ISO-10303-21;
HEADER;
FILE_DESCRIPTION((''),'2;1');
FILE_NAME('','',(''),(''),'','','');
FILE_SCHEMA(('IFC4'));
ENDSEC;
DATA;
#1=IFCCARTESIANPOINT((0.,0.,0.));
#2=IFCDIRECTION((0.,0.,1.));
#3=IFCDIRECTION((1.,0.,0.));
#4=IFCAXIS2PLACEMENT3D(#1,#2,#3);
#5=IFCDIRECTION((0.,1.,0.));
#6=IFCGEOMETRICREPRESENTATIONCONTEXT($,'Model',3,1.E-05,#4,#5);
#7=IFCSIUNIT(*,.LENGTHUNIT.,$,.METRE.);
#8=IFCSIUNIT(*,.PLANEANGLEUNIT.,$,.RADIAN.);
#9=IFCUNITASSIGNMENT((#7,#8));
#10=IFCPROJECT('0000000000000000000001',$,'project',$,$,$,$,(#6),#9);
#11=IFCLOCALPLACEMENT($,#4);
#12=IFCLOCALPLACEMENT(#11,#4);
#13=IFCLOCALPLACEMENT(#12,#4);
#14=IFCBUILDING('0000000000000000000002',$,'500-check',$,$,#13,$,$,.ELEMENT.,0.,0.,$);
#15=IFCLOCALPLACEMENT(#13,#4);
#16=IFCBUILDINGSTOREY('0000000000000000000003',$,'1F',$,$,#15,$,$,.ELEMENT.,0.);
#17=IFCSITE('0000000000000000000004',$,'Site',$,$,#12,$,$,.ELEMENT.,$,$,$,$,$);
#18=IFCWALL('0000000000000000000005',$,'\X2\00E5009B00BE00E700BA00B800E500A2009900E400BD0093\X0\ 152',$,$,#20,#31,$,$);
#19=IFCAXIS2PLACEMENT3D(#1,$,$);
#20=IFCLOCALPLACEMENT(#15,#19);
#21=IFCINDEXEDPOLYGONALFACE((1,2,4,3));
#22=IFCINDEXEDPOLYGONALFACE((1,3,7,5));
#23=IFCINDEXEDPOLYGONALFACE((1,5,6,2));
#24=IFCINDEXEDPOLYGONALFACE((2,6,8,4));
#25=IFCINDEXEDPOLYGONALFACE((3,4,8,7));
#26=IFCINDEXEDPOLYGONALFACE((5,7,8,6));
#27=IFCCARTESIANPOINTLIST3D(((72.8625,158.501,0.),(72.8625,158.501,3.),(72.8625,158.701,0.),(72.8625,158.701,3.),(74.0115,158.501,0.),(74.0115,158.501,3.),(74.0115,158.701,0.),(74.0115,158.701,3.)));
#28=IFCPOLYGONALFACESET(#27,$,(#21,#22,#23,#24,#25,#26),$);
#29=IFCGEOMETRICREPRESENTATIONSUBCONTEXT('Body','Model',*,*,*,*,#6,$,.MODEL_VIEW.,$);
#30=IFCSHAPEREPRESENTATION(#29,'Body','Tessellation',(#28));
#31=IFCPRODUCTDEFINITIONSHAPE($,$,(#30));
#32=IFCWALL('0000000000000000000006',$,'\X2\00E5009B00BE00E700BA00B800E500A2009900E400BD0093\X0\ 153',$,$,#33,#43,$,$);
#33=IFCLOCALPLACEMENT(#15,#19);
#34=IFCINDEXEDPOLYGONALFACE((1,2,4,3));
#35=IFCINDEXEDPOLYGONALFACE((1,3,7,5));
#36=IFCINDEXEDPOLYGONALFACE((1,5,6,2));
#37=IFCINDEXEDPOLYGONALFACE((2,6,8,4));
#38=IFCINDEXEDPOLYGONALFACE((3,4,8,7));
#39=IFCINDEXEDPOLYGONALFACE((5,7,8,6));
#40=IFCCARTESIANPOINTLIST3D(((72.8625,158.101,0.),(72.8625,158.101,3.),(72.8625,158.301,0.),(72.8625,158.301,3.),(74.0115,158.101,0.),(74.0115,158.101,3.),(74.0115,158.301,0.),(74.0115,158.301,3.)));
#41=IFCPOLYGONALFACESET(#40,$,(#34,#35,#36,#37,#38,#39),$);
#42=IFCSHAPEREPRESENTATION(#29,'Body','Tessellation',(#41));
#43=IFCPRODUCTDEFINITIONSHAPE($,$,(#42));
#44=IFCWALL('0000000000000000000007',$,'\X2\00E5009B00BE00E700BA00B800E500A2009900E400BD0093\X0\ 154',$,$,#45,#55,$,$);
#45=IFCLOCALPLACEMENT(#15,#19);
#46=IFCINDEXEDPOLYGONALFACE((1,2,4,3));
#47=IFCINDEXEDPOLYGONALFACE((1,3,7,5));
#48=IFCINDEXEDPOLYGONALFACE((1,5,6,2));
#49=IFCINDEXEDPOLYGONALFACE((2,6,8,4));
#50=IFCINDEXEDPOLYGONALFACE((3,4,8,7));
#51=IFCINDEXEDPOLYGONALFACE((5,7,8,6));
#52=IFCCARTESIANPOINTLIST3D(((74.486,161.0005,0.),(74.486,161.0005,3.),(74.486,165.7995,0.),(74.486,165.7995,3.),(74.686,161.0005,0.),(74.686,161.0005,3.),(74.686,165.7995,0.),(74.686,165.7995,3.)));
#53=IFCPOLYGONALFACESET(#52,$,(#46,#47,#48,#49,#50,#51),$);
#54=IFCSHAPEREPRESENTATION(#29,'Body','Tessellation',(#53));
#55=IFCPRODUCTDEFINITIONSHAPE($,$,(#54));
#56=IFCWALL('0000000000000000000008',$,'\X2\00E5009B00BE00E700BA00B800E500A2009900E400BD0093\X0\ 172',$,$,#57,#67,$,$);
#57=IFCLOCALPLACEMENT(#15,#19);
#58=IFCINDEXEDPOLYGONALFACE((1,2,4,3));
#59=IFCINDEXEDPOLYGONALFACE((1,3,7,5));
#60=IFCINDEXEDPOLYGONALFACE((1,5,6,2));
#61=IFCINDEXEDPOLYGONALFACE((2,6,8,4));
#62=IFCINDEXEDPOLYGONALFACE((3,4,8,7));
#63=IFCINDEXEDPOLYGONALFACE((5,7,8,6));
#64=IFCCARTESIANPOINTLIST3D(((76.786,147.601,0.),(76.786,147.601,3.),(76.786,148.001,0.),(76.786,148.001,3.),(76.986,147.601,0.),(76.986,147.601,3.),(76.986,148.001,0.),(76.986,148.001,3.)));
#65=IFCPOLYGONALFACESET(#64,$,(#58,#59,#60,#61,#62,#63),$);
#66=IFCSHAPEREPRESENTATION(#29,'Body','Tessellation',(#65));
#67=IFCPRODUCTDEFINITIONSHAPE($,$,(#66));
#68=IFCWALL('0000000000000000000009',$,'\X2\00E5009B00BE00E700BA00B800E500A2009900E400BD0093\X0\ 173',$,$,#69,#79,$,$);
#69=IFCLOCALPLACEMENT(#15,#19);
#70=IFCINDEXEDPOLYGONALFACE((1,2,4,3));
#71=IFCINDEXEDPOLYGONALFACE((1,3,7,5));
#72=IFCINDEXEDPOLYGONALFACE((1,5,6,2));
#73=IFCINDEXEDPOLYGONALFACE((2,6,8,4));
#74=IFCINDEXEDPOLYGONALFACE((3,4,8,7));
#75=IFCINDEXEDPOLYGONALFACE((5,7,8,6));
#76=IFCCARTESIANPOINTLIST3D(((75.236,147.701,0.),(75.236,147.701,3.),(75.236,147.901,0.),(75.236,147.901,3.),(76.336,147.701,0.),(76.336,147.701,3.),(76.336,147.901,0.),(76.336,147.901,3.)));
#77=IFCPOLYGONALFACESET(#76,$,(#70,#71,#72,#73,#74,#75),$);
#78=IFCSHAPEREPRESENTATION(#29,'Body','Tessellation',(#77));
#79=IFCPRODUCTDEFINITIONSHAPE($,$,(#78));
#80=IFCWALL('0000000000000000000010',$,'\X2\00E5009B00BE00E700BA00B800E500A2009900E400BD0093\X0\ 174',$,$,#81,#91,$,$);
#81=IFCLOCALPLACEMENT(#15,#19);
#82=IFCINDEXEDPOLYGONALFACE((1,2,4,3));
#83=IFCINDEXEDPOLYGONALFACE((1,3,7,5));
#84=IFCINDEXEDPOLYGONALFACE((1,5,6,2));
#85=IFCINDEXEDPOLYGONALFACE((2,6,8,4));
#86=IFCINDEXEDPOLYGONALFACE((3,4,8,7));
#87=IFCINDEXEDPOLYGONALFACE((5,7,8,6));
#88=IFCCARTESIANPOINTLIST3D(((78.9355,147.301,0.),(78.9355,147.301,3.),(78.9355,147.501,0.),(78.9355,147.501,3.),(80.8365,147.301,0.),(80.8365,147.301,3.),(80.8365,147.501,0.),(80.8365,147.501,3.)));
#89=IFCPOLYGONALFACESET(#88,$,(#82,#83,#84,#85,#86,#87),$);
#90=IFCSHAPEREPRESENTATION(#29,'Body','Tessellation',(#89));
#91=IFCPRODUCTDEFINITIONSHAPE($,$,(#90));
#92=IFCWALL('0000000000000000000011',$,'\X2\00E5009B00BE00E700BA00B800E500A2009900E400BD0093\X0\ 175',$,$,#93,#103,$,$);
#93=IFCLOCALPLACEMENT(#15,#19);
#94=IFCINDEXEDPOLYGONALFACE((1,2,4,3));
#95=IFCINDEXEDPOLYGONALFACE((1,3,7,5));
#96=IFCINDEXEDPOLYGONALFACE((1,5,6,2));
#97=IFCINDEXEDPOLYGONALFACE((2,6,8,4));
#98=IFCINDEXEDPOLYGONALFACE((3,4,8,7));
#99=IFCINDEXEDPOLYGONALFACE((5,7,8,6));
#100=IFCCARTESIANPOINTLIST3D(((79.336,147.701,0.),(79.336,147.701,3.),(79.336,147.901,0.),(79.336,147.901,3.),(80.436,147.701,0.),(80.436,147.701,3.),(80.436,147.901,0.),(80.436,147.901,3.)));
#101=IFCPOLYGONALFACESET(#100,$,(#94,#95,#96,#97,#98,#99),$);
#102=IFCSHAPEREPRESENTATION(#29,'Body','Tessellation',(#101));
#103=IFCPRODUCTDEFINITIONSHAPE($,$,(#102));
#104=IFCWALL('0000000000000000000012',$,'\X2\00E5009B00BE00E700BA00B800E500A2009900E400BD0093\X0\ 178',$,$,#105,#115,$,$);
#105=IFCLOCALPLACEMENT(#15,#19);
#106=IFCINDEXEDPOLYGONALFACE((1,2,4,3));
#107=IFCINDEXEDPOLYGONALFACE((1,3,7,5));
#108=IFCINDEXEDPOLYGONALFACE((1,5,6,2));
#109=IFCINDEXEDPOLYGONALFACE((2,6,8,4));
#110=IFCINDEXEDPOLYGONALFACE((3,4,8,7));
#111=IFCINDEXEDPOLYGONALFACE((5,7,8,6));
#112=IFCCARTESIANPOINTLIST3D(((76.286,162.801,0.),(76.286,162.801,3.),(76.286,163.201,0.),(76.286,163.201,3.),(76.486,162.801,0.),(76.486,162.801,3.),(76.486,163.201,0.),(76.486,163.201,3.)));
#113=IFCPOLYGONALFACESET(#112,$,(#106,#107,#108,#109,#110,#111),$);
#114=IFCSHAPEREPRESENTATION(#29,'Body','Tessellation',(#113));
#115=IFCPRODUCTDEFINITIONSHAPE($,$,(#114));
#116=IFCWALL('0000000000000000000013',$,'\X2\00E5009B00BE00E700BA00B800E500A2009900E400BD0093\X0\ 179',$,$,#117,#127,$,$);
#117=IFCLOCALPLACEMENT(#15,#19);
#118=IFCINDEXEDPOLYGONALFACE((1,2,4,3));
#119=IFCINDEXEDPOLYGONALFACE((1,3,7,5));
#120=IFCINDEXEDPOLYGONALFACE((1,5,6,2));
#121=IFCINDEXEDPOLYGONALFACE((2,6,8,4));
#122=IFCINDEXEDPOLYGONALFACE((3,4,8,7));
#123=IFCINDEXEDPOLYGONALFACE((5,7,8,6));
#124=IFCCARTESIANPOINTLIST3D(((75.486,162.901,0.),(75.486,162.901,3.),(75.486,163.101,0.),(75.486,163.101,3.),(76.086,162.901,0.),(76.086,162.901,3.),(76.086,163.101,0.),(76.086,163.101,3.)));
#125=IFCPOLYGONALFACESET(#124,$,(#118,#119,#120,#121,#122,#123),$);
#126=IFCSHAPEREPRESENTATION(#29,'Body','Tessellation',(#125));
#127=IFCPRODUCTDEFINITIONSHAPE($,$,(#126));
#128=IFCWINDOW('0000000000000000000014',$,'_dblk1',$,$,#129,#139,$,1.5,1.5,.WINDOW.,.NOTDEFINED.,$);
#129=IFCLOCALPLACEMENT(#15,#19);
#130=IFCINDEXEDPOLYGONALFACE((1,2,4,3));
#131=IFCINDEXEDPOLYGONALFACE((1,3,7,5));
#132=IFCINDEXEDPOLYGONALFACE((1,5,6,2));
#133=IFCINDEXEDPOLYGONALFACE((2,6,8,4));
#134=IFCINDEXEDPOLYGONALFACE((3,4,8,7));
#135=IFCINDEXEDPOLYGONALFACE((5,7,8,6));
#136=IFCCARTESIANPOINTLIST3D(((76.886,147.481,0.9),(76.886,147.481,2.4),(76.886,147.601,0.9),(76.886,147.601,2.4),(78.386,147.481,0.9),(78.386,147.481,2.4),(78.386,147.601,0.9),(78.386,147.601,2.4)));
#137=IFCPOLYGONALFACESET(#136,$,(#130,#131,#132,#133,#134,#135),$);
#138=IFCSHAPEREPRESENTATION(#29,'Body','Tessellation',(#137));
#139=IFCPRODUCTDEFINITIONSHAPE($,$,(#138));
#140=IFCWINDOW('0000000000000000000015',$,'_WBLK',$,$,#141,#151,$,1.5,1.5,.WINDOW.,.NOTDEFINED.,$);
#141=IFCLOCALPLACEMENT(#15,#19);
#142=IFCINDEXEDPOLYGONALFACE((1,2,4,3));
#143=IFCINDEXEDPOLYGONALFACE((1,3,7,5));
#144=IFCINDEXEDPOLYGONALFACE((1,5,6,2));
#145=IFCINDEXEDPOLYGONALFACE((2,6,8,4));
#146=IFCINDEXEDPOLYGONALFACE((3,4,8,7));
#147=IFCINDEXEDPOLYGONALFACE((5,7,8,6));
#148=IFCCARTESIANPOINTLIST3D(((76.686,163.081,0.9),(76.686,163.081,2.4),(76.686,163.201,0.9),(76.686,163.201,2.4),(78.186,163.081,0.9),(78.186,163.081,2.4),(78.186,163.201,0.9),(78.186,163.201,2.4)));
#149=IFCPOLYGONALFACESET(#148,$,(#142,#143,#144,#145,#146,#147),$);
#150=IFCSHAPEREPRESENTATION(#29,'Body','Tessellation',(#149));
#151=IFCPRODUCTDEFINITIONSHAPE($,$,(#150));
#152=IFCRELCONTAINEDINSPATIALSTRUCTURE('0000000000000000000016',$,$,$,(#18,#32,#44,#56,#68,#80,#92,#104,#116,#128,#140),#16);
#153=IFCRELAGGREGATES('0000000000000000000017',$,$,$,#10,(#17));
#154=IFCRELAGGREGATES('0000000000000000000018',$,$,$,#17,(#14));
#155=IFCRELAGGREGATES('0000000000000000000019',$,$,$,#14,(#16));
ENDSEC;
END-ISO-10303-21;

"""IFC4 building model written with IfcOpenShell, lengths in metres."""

from ifc_helpers import new_model, si_unit, direction, frame, frame_2d, origin_with_axes, place, context, subcontext, project, spatial, rectangle, extrude, element, save


model = new_model("IFC4")

# Units and contexts
model_context = context("Model", 3, precision=1e-05, world=origin_with_axes(), true_north=direction((0.0, 1.0, 0.0)))
body_context = subcontext(model_context, "Body", "Model", "MODEL_VIEW")
ifc_project = project(units=[si_unit("LENGTHUNIT", "METRE"), si_unit("PLANEANGLEUNIT", "RADIAN")], contexts=[model_context])

# Site, building, storey
placement = place(None, origin_with_axes())
site_placement = place(placement, origin_with_axes())
site = spatial("IfcSite", under=ifc_project, at=site_placement, Name="Site", CompositionType="ELEMENT")
building_placement = place(site_placement, origin_with_axes())
building = spatial("IfcBuilding", under=site, at=building_placement, Name="500-check", CompositionType="ELEMENT", ElevationOfRefHeight=0.0, ElevationOfTerrain=0.0)
storey_placement = place(building_placement, origin_with_axes())
storey = spatial("IfcBuildingStorey", under=building, at=storey_placement, Name="1F", CompositionType="ELEMENT", Elevation=0.0)

# Walls
for number, where, z_axis, x_axis, name in (
    (1, (73.437, 158.601, 0.0), (0.0, 0.0, 1.0), (1.0, 0.0, 0.0), "å\u009b¾çº¸å¢\u0099ä½\u0093 152"),
    (2, (73.437, 158.201, 0.0), (0.0, 0.0, 1.0), (1.0, 0.0, 0.0), "å\u009b¾çº¸å¢\u0099ä½\u0093 153"),
):
    element("IfcWall", number, at=place(storey_placement, frame(where, z_axis=z_axis, x_axis=x_axis)), inside=storey, Name=name, context=body_context, shape_type="SweptSolid", body=[
        extrude(rectangle(XDim=1.149, YDim=0.2, at=frame_2d((0.0, 0.0), x_axis=(1.0, 0.0, 0.0))), frame((0.0, 0.0, 0.0), z_axis=(0.0, 0.0, 1.0)), (0.0, 0.0, 1.0), 3.0),
    ])
wall_1_placement = place(storey_placement, frame((74.586, 163.4, 0.0), z_axis=(0.0, 0.0, 1.0), x_axis=(0.0, -1.0, 0.0)))
element("IfcWall", 3, at=wall_1_placement, inside=storey, Name="å\u009b¾çº¸å¢\u0099ä½\u0093 154", context=body_context, shape_type="SweptSolid", body=[
    extrude(rectangle(XDim=4.799, YDim=0.2, at=frame_2d((0.0, 0.0), x_axis=(1.0, 0.0, 0.0))), frame((0.0, 0.0, 0.0), z_axis=(0.0, 0.0, 1.0)), (0.0, 0.0, 1.0), 3.0),
])
wall_2_placement = place(storey_placement, frame((76.886, 147.801, 0.0), z_axis=(0.0, 0.0, 1.0), x_axis=(0.0, -1.0, 0.0)))
element("IfcWall", 4, at=wall_2_placement, inside=storey, Name="å\u009b¾çº¸å¢\u0099ä½\u0093 172", context=body_context, shape_type="SweptSolid", body=[
    extrude(rectangle(XDim=0.4, YDim=0.2, at=frame_2d((0.0, 0.0), x_axis=(1.0, 0.0, 0.0))), frame((0.0, 0.0, 0.0), z_axis=(0.0, 0.0, 1.0)), (0.0, 0.0, 1.0), 3.0),
])
wall_3_placement = place(storey_placement, frame((75.786, 147.801, 0.0), z_axis=(0.0, 0.0, 1.0), x_axis=(1.0, 0.0, 0.0)))
element("IfcWall", 5, at=wall_3_placement, inside=storey, Name="å\u009b¾çº¸å¢\u0099ä½\u0093 173", context=body_context, shape_type="SweptSolid", body=[
    extrude(rectangle(XDim=1.1, YDim=0.2, at=frame_2d((0.0, 0.0), x_axis=(1.0, 0.0, 0.0))), frame((0.0, 0.0, 0.0), z_axis=(0.0, 0.0, 1.0)), (0.0, 0.0, 1.0), 3.0),
])
wall_4_placement = place(storey_placement, frame((79.886, 147.401, 0.0), z_axis=(0.0, 0.0, 1.0), x_axis=(1.0, 0.0, 0.0)))
element("IfcWall", 6, at=wall_4_placement, inside=storey, Name="å\u009b¾çº¸å¢\u0099ä½\u0093 174", context=body_context, shape_type="SweptSolid", body=[
    extrude(rectangle(XDim=1.901, YDim=0.2, at=frame_2d((0.0, 0.0), x_axis=(1.0, 0.0, 0.0))), frame((0.0, 0.0, 0.0), z_axis=(0.0, 0.0, 1.0)), (0.0, 0.0, 1.0), 3.0),
])
wall_5_placement = place(storey_placement, frame((79.886, 147.801, 0.0), z_axis=(0.0, 0.0, 1.0), x_axis=(1.0, 0.0, 0.0)))
element("IfcWall", 7, at=wall_5_placement, inside=storey, Name="å\u009b¾çº¸å¢\u0099ä½\u0093 175", context=body_context, shape_type="SweptSolid", body=[
    extrude(rectangle(XDim=1.1, YDim=0.2, at=frame_2d((0.0, 0.0), x_axis=(1.0, 0.0, 0.0))), frame((0.0, 0.0, 0.0), z_axis=(0.0, 0.0, 1.0)), (0.0, 0.0, 1.0), 3.0),
])
wall_6_placement = place(storey_placement, frame((76.386, 163.001, 0.0), z_axis=(0.0, 0.0, 1.0), x_axis=(0.0, 1.0, 0.0)))
element("IfcWall", 8, at=wall_6_placement, inside=storey, Name="å\u009b¾çº¸å¢\u0099ä½\u0093 178", context=body_context, shape_type="SweptSolid", body=[
    extrude(rectangle(XDim=0.4, YDim=0.2, at=frame_2d((0.0, 0.0), x_axis=(1.0, 0.0, 0.0))), frame((0.0, 0.0, 0.0), z_axis=(0.0, 0.0, 1.0)), (0.0, 0.0, 1.0), 3.0),
])
wall_7_placement = place(storey_placement, frame((75.786, 163.001, 0.0), z_axis=(0.0, 0.0, 1.0), x_axis=(1.0, 0.0, 0.0)))
element("IfcWall", 9, at=wall_7_placement, inside=storey, Name="å\u009b¾çº¸å¢\u0099ä½\u0093 179", context=body_context, shape_type="SweptSolid", body=[
    extrude(rectangle(XDim=0.6, YDim=0.2, at=frame_2d((0.0, 0.0), x_axis=(1.0, 0.0, 0.0))), frame((0.0, 0.0, 0.0), z_axis=(0.0, 0.0, 1.0)), (0.0, 0.0, 1.0), 3.0),
])

# Windows
for number, where, z_axis, x_axis, name in (
    (10, (77.636, 147.541, 0.9), (0.0, 0.0, 1.0), (1.0, 0.0, 0.0), "_dblk1"),
    (11, (77.436, 163.141, 0.9), (0.0, 0.0, 1.0), (1.0, 0.0, 0.0), "_WBLK"),
):
    element("IfcWindow", number, at=place(storey_placement, frame(where, z_axis=z_axis, x_axis=x_axis)), inside=storey, Name=name, OverallHeight=1.5, OverallWidth=1.5, PartitioningType="NOTDEFINED", PredefinedType="WINDOW", context=body_context, shape_type="SweptSolid", body=[
        extrude(rectangle(XDim=1.5, YDim=0.12, at=frame_2d((0.0, 0.0), x_axis=(1.0, 0.0, 0.0))), frame((0.0, 0.0, 0.0), z_axis=(0.0, 0.0, 1.0)), (0.0, 0.0, 1.0), 1.5),
    ])

save(model, "model.ifc")
